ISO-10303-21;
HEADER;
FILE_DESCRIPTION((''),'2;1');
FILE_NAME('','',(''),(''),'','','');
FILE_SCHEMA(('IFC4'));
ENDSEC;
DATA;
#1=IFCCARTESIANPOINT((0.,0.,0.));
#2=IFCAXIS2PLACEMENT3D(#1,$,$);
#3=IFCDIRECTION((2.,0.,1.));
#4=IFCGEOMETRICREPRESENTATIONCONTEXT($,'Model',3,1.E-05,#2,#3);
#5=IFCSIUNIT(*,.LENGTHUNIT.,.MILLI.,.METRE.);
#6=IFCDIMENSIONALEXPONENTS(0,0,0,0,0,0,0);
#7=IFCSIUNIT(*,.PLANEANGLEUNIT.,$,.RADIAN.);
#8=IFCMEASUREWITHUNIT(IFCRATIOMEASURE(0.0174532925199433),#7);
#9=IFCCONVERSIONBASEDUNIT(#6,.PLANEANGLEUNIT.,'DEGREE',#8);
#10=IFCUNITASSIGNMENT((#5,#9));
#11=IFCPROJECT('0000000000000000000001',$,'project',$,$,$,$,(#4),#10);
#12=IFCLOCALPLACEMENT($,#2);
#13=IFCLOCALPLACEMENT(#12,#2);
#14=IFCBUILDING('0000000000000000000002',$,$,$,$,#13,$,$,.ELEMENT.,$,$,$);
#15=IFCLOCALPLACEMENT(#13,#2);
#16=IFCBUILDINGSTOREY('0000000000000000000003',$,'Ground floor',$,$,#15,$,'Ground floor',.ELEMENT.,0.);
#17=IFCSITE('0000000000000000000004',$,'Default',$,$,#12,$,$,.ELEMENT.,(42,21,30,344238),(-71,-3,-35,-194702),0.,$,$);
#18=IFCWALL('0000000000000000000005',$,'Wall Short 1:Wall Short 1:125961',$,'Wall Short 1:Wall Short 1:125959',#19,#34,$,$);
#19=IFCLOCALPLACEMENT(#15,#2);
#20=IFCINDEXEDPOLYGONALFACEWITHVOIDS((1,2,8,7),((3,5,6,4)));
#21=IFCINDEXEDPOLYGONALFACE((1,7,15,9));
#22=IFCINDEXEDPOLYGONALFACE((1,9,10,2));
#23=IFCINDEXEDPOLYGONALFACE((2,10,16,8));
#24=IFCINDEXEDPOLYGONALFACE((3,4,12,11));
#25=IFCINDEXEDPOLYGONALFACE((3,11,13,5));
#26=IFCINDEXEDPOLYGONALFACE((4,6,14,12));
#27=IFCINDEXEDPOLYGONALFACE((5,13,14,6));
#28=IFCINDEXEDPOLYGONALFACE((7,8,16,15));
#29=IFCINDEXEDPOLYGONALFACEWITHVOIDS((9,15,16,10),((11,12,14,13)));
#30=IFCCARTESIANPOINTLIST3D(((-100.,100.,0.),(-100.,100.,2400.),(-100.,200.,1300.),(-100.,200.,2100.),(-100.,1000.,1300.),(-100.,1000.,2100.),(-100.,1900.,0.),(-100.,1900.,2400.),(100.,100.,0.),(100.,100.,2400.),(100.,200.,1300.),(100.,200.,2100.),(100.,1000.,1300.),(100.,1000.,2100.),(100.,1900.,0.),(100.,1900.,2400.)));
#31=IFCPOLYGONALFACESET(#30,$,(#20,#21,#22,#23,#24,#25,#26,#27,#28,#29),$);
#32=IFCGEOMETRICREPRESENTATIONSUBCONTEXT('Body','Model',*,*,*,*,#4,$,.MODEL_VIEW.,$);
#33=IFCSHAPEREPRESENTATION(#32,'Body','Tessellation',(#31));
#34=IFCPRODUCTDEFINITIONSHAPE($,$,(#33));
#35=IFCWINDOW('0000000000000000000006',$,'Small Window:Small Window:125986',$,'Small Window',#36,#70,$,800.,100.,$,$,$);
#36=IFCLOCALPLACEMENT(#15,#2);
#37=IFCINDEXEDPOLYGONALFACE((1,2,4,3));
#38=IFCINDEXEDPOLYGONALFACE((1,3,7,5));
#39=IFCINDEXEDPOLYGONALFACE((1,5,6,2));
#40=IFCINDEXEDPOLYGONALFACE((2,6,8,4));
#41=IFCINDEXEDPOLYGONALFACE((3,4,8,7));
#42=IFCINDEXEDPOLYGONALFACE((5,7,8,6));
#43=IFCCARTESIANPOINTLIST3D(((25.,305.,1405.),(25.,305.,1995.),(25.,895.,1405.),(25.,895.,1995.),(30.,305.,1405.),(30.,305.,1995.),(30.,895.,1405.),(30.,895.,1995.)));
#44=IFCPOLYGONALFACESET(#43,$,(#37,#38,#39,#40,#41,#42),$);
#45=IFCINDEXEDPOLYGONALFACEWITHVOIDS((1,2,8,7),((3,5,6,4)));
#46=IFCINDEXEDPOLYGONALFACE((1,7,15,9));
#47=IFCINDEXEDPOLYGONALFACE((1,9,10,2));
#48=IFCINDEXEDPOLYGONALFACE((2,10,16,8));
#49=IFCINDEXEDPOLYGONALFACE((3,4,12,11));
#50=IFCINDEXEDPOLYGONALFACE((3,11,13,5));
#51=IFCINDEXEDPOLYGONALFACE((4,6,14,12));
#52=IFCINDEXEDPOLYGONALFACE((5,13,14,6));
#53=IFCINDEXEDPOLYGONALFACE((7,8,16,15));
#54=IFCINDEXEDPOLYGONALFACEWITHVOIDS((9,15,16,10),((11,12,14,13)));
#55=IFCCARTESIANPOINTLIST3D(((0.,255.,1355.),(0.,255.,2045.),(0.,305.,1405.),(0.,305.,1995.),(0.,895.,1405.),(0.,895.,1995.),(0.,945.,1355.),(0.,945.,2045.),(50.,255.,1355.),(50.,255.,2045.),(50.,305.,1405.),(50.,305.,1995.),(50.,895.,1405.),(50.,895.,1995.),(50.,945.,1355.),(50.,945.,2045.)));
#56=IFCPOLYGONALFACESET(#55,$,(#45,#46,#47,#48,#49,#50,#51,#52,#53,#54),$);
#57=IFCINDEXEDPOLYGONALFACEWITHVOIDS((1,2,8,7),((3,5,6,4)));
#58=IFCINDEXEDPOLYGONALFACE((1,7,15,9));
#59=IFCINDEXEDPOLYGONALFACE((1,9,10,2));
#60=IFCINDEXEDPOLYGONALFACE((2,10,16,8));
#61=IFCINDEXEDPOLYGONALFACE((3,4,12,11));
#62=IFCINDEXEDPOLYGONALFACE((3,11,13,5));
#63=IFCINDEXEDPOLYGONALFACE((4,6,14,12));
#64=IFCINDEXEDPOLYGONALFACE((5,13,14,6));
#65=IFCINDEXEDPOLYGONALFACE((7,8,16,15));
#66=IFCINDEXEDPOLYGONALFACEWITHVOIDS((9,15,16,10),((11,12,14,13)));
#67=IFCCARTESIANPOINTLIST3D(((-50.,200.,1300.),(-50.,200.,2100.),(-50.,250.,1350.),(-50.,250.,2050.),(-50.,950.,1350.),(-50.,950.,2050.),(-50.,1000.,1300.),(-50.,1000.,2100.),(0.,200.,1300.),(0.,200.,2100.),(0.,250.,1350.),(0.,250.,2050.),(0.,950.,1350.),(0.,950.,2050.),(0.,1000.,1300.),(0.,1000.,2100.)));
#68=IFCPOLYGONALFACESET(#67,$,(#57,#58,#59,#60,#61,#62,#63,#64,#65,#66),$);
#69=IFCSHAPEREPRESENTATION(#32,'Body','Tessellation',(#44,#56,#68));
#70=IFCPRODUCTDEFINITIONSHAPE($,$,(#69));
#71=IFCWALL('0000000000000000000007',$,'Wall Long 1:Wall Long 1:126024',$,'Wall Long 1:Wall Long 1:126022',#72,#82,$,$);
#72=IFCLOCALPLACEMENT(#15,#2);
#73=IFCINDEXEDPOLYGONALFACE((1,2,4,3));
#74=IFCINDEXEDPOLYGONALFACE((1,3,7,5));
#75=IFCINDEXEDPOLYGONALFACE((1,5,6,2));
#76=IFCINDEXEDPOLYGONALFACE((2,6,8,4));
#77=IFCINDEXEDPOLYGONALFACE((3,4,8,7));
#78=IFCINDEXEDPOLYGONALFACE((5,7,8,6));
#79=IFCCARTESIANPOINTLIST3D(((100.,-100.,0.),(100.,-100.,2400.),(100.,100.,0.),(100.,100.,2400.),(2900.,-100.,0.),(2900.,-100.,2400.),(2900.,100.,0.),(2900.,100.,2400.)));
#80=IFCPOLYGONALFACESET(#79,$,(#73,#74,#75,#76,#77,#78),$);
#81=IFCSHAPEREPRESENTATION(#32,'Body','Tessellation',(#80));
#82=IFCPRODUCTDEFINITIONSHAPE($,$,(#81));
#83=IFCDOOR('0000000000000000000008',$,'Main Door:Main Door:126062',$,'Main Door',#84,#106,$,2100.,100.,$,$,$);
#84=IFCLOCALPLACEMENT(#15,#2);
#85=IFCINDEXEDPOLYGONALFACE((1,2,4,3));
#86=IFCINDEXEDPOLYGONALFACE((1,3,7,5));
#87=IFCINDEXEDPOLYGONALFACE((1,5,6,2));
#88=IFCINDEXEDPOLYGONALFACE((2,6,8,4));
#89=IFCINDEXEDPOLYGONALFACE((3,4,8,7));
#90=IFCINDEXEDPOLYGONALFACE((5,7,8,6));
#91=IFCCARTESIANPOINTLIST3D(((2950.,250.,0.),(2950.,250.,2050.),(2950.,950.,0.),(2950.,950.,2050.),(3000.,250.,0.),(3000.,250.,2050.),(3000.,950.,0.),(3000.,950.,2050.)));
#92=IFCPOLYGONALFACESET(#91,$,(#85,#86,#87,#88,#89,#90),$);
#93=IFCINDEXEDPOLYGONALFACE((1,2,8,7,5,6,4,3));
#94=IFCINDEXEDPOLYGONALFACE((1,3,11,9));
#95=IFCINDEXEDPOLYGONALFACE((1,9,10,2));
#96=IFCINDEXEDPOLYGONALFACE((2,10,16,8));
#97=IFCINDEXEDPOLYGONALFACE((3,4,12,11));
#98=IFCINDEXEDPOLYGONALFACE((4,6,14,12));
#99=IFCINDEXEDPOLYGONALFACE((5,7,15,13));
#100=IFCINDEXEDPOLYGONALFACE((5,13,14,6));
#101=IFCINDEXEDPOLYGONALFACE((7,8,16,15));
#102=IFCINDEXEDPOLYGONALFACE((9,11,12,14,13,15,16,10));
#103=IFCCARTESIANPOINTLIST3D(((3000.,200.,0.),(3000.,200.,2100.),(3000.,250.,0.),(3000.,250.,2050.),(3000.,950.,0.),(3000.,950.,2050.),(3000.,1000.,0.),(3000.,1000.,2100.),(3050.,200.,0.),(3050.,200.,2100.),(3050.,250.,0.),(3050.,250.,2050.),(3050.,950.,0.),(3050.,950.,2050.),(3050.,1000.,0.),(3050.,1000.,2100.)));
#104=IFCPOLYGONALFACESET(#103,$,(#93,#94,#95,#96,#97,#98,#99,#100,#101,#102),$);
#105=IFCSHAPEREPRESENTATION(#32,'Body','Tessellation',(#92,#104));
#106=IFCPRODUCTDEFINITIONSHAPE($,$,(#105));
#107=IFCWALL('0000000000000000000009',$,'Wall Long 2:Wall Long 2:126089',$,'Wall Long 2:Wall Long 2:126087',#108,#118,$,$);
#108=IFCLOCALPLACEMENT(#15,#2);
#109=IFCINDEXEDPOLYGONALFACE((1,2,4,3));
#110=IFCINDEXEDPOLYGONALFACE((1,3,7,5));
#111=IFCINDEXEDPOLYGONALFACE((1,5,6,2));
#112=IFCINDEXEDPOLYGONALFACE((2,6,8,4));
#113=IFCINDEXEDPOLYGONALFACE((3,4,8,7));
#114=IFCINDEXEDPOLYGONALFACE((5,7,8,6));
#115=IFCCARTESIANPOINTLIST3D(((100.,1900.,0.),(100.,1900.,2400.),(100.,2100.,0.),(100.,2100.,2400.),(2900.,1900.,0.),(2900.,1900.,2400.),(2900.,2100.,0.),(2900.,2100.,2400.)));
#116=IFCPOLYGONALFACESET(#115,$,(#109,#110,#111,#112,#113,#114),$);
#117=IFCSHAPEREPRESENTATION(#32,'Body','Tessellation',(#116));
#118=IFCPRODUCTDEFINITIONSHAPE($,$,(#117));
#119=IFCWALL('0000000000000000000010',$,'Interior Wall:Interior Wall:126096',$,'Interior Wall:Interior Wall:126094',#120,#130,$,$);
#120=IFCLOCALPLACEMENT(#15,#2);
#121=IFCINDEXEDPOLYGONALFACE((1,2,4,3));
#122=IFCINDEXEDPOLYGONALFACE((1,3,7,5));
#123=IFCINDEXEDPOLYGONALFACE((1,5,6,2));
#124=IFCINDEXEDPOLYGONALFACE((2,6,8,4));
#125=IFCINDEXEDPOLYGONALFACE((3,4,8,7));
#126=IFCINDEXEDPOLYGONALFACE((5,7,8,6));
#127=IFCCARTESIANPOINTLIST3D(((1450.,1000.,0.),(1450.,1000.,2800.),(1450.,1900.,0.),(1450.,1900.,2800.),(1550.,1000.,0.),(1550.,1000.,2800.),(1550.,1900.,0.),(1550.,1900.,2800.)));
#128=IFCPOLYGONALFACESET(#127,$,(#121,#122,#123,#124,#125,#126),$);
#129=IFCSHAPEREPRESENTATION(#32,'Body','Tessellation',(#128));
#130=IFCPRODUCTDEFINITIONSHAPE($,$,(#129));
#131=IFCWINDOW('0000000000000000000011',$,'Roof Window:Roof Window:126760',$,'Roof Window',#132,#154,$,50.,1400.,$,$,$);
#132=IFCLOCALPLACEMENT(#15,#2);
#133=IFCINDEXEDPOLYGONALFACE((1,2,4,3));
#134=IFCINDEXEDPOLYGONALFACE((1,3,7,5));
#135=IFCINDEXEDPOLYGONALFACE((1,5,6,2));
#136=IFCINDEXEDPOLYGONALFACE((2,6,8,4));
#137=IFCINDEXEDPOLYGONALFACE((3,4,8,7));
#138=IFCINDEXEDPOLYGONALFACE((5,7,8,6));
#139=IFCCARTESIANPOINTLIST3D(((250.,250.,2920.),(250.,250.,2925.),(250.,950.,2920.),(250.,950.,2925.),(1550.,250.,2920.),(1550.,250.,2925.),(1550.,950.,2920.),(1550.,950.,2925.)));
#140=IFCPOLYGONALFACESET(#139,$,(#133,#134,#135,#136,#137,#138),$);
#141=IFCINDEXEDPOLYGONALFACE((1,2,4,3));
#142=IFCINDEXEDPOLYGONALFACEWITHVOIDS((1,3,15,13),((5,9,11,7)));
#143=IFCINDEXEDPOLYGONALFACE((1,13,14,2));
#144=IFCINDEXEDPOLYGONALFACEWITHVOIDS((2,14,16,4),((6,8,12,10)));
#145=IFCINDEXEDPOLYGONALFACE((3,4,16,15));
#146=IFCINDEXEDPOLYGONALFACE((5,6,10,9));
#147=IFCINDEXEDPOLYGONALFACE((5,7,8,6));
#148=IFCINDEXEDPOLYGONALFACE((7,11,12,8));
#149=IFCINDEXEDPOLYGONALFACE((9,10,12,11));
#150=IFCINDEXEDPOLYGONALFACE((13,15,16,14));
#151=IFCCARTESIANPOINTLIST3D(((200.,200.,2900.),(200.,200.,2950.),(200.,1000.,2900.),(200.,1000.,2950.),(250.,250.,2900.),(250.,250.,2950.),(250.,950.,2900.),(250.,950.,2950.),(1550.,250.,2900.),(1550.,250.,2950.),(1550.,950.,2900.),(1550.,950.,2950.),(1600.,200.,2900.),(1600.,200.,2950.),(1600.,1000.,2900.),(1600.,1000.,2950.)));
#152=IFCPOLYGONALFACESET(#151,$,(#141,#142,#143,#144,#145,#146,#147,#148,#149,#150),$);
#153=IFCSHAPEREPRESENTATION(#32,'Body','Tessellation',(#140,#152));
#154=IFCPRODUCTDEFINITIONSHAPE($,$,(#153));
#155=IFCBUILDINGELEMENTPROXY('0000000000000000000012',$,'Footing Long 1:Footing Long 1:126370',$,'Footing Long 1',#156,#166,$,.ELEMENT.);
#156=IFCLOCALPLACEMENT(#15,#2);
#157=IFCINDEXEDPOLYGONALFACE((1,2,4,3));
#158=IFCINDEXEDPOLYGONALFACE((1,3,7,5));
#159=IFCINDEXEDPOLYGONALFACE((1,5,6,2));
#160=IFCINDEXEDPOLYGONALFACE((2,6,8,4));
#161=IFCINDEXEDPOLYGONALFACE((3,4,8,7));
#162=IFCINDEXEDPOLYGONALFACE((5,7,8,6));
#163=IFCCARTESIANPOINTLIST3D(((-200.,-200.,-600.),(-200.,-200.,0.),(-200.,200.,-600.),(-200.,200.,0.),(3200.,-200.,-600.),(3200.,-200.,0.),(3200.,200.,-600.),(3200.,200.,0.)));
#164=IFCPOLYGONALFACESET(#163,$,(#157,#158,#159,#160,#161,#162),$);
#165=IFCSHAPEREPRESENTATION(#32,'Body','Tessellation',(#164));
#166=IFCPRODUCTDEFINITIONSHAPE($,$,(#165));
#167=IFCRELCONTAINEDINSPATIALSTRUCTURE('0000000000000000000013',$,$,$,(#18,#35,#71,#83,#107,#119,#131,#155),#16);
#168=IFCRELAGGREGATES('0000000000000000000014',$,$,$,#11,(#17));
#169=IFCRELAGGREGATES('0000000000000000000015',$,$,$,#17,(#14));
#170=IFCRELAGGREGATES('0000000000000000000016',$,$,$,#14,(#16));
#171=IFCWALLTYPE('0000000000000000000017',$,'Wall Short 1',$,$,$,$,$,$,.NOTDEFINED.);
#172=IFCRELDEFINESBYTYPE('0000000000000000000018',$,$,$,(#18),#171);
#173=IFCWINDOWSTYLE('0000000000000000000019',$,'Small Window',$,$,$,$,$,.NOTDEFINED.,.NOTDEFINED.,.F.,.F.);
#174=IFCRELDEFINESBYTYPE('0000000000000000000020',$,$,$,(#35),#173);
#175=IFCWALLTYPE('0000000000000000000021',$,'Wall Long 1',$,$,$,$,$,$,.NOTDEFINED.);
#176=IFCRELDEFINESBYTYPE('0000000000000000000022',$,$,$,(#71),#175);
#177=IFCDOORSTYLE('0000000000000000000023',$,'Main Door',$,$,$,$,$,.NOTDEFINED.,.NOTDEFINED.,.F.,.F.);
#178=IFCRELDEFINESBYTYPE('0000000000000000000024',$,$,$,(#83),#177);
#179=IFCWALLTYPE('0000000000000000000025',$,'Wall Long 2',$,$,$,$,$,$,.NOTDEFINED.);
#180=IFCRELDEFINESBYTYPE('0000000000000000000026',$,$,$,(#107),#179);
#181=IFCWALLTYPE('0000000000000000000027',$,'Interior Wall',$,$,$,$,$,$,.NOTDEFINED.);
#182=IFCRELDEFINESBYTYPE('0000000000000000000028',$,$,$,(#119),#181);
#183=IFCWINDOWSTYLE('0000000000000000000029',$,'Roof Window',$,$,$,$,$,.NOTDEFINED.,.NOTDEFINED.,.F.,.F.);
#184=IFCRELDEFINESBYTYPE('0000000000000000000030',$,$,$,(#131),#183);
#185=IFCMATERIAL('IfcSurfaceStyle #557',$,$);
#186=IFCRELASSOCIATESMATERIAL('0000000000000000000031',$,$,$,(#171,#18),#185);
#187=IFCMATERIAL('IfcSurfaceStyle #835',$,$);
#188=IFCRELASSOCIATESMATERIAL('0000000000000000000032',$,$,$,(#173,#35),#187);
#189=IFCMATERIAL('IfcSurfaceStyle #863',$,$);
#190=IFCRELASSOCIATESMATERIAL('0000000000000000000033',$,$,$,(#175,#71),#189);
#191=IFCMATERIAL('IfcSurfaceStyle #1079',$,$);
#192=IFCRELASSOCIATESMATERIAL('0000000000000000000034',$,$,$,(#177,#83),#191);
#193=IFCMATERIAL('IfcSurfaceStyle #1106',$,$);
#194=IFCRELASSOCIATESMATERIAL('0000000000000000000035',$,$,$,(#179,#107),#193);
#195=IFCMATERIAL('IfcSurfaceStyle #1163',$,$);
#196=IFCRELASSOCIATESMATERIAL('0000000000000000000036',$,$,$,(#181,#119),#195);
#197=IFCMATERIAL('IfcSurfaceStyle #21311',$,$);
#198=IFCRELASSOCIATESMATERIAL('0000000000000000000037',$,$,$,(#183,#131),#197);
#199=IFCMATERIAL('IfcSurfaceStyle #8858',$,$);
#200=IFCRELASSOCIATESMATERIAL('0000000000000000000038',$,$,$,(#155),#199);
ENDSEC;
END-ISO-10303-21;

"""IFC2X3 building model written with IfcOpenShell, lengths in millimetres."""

from ifc_helpers import new_model, entity, si_unit, converted_unit, direction, frame, frame_2d, origin, origin_2d_with_axis, place, context, subcontext, project, spatial, polyline, rectangle, outline, extrude, source, transform, mapped, material, type_object, type_shapes, element, save


model = new_model("IFC2X3")

# Units and contexts
model_context = context("Model", 3, precision=1e-05, world=origin(), true_north=direction((2.0, 0.0, 1.0)))
body_context = subcontext(model_context, "Body", "Model", "MODEL_VIEW")
ifc_project = project(units=[si_unit("LENGTHUNIT", "METRE", prefix="MILLI"), converted_unit("PLANEANGLEUNIT", "DEGREE", entity("IfcRatioMeasure", 0.0174532925199433), si_unit("PLANEANGLEUNIT", "RADIAN"), dimensions=[0, 0, 0, 0, 0, 0, 0])], contexts=[model_context])

# Site, building, storey
site_placement = place(None, origin())
site = spatial("IfcSite", under=ifc_project, at=site_placement, Name="Default", CompositionType="ELEMENT", RefLatitude=(42, 21, 30, 344238), RefLongitude=(-71, -3, -35, -194702), RefElevation=0.0)
building_placement = place(site_placement, origin())
building = spatial("IfcBuilding", under=site, at=building_placement, CompositionType="ELEMENT")
storey_placement = place(building_placement, origin())
storey = spatial("IfcBuildingStorey", under=building, at=storey_placement, Name="Ground floor", LongName="Ground floor", CompositionType="ELEMENT", Elevation=0.0)

# Wall, opening
ifc_material_1 = material(Name="IfcSurfaceStyle #557")
wall_type_1 = type_object("IfcWallType", Name="Wall Short 1", PredefinedType="NOTDEFINED", material=ifc_material_1)
wall_1_placement = place(building_placement, frame((-100.0, 100.0, 0.0), z_axis=(0.0, 0.0, 1.0), x_axis=(0.0, 1.0, 0.0)))
wall_1 = element("IfcWall", 1, at=wall_1_placement, inside=storey, type_object=wall_type_1, material=ifc_material_1, Name="Wall Short 1:Wall Short 1:125961", ObjectType="Wall Short 1:Wall Short 1:125959", context=body_context, shape_type="SweptSolid", body=[
    extrude(rectangle(XDim=200.0, YDim=1800.0, at=origin_2d_with_axis()), frame((900.0, -100.0, 0.0), z_axis=(0.0, 0.0, 1.0), x_axis=(0.0, -1.0, 0.0)), (0.0, 0.0, 1.0), 2400.0),
])
opening_placement = place(building_placement, frame((-100.0, 100.0, 0.0), z_axis=(0.0, 0.0, 1.0), x_axis=(0.0, 1.0, 0.0)))
element("IfcOpeningElement", 2, at=opening_placement, cuts=wall_1, ObjectType="Opening", context=body_context, shape_type="SweptSolid", body=[
    extrude(rectangle(XDim=800.0, YDim=800.0, at=frame_2d((0.0, 0.0), x_axis=(0.0, 1.0))), frame((500.0, 0.0, 1700.0), z_axis=(0.0, -1.0, 0.0), x_axis=(-1.0, 0.0, 0.0)), (0.0, 0.0, 1.0), 200.0),
])

# Window
ifc_material_2 = material(Name="IfcSurfaceStyle #835")
window_style_1 = type_object("IfcWindowStyle", Name="Small Window", ConstructionType="NOTDEFINED", OperationType="NOTDEFINED", ParameterTakesPrecedence=False, Sizeable=False, material=ifc_material_2)
shared_shape_1 = source(origin(), body_context, "Body", "SweptSolid", [
    extrude(rectangle(XDim=5.0, YDim=590.0, at=frame_2d((0.0, 0.0), x_axis=(1.0, 0.0))), frame((27.5, 600.0, 1405.0), z_axis=(0.0, 0.0, 1.0), x_axis=(-1.0, 0.0, 0.0)), (0.0, 0.0, 1.0), 590.0),
    extrude(outline(polyline([(-345.0, -345.0), (345.0, -345.0), (345.0, 345.0), (-345.0, 345.0), (-345.0, -345.0)]), holes=[polyline([(-295.0, 295.0), (295.0, 295.0), (295.0, -295.0), (-295.0, -295.0), (-295.0, 295.0)])]), frame((0.0, 600.0, 1700.0), z_axis=(1.0, 0.0, 0.0), x_axis=(0.0, 1.0, 0.0)), (0.0, 0.0, 1.0), 50.0),
    extrude(outline(polyline([(-400.0, -400.0), (400.0, -400.0), (400.0, 400.0), (-400.0, 400.0), (-400.0, -400.0)]), holes=[polyline([(-350.0, 350.0), (350.0, 350.0), (350.0, -350.0), (-350.0, -350.0), (-350.0, 350.0)])]), frame((-50.0, 600.0, 1700.0), z_axis=(1.0, 0.0, 0.0), x_axis=(0.0, 1.0, 0.0)), (0.0, 0.0, 1.0), 50.0),
])
type_shapes(window_style_1, [shared_shape_1])
window_1_placement = place(building_placement, origin())
element("IfcWindow", 3, at=window_1_placement, inside=storey, type_object=window_style_1, material=ifc_material_2, Name="Small Window:Small Window:125986", ObjectType="Small Window", OverallHeight=800.0, OverallWidth=100.0, context=body_context, shape_type="MappedRepresentation", body=[
    mapped(shared_shape_1, transform((0.0, 0.0, 0.0), scale=1.0)),
])

# Wall
ifc_material_3 = material(Name="IfcSurfaceStyle #863")
wall_type_2 = type_object("IfcWallType", Name="Wall Long 1", PredefinedType="NOTDEFINED", material=ifc_material_3)
wall_2_placement = place(building_placement, frame((100.0, -100.0, 0.0)))
element("IfcWall", 4, at=wall_2_placement, inside=storey, type_object=wall_type_2, material=ifc_material_3, Name="Wall Long 1:Wall Long 1:126024", ObjectType="Wall Long 1:Wall Long 1:126022", context=body_context, shape_type="SweptSolid", body=[
    extrude(rectangle(XDim=200.0, YDim=2800.0, at=origin_2d_with_axis()), frame((1400.0, 100.0, 0.0), z_axis=(0.0, 0.0, 1.0), x_axis=(0.0, 1.0, 0.0)), (0.0, 0.0, 1.0), 2400.0),
])

# Door
ifc_material_4 = material(Name="IfcSurfaceStyle #1079")
door_style_1 = type_object("IfcDoorStyle", Name="Main Door", ConstructionType="NOTDEFINED", OperationType="NOTDEFINED", ParameterTakesPrecedence=False, Sizeable=False, material=ifc_material_4)
shared_shape_2 = source(origin(), body_context, "Body", "SweptSolid", [
    extrude(rectangle(XDim=50.0, YDim=700.0, at=frame_2d((0.0, 0.0), x_axis=(1.0, 0.0))), frame((2975.0, 600.0, 0.0)), (0.0, 0.0, 1.0), 2050.0),
    extrude(outline(polyline([(-400.0, -1062.5), (400.0, -1062.5), (400.0, 1037.5), (350.0, 1037.5), (350.0, -1012.5), (-350.0, -1012.5), (-350.0, 1037.5), (-400.0, 1037.5), (-400.0, -1062.5)])), frame((3000.0, 600.0, 1037.5), z_axis=(1.0, 0.0, 0.0), x_axis=(0.0, -1.0, 0.0)), (0.0, 0.0, 1.0), 50.0),
])
type_shapes(door_style_1, [shared_shape_2])
door_1_placement = place(building_placement, origin())
element("IfcDoor", 5, at=door_1_placement, inside=storey, type_object=door_style_1, material=ifc_material_4, Name="Main Door:Main Door:126062", ObjectType="Main Door", OverallHeight=2100.0, OverallWidth=100.0, context=body_context, shape_type="MappedRepresentation", body=[
    mapped(shared_shape_2, transform((0.0, 0.0, 0.0), scale=1.0)),
])

# Walls
ifc_material_5 = material(Name="IfcSurfaceStyle #1106")
wall_type_3 = type_object("IfcWallType", Name="Wall Long 2", PredefinedType="NOTDEFINED", material=ifc_material_5)
wall_3_placement = place(building_placement, frame((100.0, 1900.0, 0.0)))
element("IfcWall", 6, at=wall_3_placement, inside=storey, type_object=wall_type_3, material=ifc_material_5, Name="Wall Long 2:Wall Long 2:126089", ObjectType="Wall Long 2:Wall Long 2:126087", context=body_context, shape_type="SweptSolid", body=[
    extrude(rectangle(XDim=200.0, YDim=2800.0, at=origin_2d_with_axis()), frame((1400.0, 100.0, 0.0), z_axis=(0.0, 0.0, 1.0), x_axis=(0.0, -1.0, 0.0)), (0.0, 0.0, 1.0), 2400.0),
])
ifc_material_6 = material(Name="IfcSurfaceStyle #1163")
wall_type_4 = type_object("IfcWallType", Name="Interior Wall", PredefinedType="NOTDEFINED", material=ifc_material_6)
wall_4_placement = place(building_placement, frame((1450.0, 1000.0, 0.0), z_axis=(0.0, 0.0, 1.0), x_axis=(0.0, 1.0, 0.0)))
element("IfcWall", 7, at=wall_4_placement, inside=storey, type_object=wall_type_4, material=ifc_material_6, Name="Interior Wall:Interior Wall:126096", ObjectType="Interior Wall:Interior Wall:126094", context=body_context, shape_type="SweptSolid", body=[
    extrude(rectangle(XDim=900.0, YDim=100.0, at=origin_2d_with_axis()), frame((450.0, -50.0, 0.0), z_axis=(0.0, 0.0, 1.0), x_axis=(-1.0, 0.0, 0.0)), (0.0, 0.0, 1.0), 2800.0),
])

# Window
ifc_material_7 = material(Name="IfcSurfaceStyle #21311")
window_style_2 = type_object("IfcWindowStyle", Name="Roof Window", ConstructionType="NOTDEFINED", OperationType="NOTDEFINED", ParameterTakesPrecedence=False, Sizeable=False, material=ifc_material_7)
shared_shape_3 = source(origin(), body_context, "Body", "SweptSolid", [
    extrude(rectangle(XDim=1300.0, YDim=700.0, at=origin_2d_with_axis()), frame((900.0, 600.0, 2920.0), z_axis=(0.0, 0.0, 1.0), x_axis=(-1.0, 0.0, 0.0)), (0.0, 0.0, 1.0), 5.0),
    extrude(outline(polyline([(-700.0, -400.0), (700.0, -400.0), (700.0, 400.0), (-700.0, 400.0), (-700.0, -400.0)]), holes=[polyline([(650.0, -350.0), (-650.0, -350.0), (-650.0, 350.0), (650.0, 350.0), (650.0, -350.0)])]), frame((900.0, 600.0, 2900.0), z_axis=(0.0, 0.0, 1.0), x_axis=(-1.0, 0.0, 0.0)), (0.0, 0.0, 1.0), 50.0),
])
type_shapes(window_style_2, [shared_shape_3])
window_2_placement = place(building_placement, origin())
element("IfcWindow", 8, at=window_2_placement, inside=storey, type_object=window_style_2, material=ifc_material_7, Name="Roof Window:Roof Window:126760", ObjectType="Roof Window", OverallHeight=50.0, OverallWidth=1400.0, context=body_context, shape_type="MappedRepresentation", body=[
    mapped(shared_shape_3, transform((0.0, 0.0, 0.0), scale=1.0)),
])

# Building element proxy
ifc_material_8 = material(Name="IfcSurfaceStyle #8858")
shared_shape_4 = source(origin(), body_context, "Body", "SweptSolid", [
    extrude(rectangle(XDim=3400.0, YDim=400.0, at=origin_2d_with_axis()), frame((1500.0, 0.0, -600.0), z_axis=(0.0, 0.0, 1.0), x_axis=(-1.0, 0.0, 0.0)), (0.0, 0.0, 1.0), 600.0),
])
proxy_1_placement = place(building_placement, origin())
element("IfcBuildingElementProxy", 9, at=proxy_1_placement, inside=storey, material=ifc_material_8, Name="Footing Long 1:Footing Long 1:126370", ObjectType="Footing Long 1", CompositionType="ELEMENT", context=body_context, shape_type="MappedRepresentation", body=[
    mapped(shared_shape_4, transform((0.0, 0.0, 0.0), scale=1.0)),
])

save(model, "model.ifc")
